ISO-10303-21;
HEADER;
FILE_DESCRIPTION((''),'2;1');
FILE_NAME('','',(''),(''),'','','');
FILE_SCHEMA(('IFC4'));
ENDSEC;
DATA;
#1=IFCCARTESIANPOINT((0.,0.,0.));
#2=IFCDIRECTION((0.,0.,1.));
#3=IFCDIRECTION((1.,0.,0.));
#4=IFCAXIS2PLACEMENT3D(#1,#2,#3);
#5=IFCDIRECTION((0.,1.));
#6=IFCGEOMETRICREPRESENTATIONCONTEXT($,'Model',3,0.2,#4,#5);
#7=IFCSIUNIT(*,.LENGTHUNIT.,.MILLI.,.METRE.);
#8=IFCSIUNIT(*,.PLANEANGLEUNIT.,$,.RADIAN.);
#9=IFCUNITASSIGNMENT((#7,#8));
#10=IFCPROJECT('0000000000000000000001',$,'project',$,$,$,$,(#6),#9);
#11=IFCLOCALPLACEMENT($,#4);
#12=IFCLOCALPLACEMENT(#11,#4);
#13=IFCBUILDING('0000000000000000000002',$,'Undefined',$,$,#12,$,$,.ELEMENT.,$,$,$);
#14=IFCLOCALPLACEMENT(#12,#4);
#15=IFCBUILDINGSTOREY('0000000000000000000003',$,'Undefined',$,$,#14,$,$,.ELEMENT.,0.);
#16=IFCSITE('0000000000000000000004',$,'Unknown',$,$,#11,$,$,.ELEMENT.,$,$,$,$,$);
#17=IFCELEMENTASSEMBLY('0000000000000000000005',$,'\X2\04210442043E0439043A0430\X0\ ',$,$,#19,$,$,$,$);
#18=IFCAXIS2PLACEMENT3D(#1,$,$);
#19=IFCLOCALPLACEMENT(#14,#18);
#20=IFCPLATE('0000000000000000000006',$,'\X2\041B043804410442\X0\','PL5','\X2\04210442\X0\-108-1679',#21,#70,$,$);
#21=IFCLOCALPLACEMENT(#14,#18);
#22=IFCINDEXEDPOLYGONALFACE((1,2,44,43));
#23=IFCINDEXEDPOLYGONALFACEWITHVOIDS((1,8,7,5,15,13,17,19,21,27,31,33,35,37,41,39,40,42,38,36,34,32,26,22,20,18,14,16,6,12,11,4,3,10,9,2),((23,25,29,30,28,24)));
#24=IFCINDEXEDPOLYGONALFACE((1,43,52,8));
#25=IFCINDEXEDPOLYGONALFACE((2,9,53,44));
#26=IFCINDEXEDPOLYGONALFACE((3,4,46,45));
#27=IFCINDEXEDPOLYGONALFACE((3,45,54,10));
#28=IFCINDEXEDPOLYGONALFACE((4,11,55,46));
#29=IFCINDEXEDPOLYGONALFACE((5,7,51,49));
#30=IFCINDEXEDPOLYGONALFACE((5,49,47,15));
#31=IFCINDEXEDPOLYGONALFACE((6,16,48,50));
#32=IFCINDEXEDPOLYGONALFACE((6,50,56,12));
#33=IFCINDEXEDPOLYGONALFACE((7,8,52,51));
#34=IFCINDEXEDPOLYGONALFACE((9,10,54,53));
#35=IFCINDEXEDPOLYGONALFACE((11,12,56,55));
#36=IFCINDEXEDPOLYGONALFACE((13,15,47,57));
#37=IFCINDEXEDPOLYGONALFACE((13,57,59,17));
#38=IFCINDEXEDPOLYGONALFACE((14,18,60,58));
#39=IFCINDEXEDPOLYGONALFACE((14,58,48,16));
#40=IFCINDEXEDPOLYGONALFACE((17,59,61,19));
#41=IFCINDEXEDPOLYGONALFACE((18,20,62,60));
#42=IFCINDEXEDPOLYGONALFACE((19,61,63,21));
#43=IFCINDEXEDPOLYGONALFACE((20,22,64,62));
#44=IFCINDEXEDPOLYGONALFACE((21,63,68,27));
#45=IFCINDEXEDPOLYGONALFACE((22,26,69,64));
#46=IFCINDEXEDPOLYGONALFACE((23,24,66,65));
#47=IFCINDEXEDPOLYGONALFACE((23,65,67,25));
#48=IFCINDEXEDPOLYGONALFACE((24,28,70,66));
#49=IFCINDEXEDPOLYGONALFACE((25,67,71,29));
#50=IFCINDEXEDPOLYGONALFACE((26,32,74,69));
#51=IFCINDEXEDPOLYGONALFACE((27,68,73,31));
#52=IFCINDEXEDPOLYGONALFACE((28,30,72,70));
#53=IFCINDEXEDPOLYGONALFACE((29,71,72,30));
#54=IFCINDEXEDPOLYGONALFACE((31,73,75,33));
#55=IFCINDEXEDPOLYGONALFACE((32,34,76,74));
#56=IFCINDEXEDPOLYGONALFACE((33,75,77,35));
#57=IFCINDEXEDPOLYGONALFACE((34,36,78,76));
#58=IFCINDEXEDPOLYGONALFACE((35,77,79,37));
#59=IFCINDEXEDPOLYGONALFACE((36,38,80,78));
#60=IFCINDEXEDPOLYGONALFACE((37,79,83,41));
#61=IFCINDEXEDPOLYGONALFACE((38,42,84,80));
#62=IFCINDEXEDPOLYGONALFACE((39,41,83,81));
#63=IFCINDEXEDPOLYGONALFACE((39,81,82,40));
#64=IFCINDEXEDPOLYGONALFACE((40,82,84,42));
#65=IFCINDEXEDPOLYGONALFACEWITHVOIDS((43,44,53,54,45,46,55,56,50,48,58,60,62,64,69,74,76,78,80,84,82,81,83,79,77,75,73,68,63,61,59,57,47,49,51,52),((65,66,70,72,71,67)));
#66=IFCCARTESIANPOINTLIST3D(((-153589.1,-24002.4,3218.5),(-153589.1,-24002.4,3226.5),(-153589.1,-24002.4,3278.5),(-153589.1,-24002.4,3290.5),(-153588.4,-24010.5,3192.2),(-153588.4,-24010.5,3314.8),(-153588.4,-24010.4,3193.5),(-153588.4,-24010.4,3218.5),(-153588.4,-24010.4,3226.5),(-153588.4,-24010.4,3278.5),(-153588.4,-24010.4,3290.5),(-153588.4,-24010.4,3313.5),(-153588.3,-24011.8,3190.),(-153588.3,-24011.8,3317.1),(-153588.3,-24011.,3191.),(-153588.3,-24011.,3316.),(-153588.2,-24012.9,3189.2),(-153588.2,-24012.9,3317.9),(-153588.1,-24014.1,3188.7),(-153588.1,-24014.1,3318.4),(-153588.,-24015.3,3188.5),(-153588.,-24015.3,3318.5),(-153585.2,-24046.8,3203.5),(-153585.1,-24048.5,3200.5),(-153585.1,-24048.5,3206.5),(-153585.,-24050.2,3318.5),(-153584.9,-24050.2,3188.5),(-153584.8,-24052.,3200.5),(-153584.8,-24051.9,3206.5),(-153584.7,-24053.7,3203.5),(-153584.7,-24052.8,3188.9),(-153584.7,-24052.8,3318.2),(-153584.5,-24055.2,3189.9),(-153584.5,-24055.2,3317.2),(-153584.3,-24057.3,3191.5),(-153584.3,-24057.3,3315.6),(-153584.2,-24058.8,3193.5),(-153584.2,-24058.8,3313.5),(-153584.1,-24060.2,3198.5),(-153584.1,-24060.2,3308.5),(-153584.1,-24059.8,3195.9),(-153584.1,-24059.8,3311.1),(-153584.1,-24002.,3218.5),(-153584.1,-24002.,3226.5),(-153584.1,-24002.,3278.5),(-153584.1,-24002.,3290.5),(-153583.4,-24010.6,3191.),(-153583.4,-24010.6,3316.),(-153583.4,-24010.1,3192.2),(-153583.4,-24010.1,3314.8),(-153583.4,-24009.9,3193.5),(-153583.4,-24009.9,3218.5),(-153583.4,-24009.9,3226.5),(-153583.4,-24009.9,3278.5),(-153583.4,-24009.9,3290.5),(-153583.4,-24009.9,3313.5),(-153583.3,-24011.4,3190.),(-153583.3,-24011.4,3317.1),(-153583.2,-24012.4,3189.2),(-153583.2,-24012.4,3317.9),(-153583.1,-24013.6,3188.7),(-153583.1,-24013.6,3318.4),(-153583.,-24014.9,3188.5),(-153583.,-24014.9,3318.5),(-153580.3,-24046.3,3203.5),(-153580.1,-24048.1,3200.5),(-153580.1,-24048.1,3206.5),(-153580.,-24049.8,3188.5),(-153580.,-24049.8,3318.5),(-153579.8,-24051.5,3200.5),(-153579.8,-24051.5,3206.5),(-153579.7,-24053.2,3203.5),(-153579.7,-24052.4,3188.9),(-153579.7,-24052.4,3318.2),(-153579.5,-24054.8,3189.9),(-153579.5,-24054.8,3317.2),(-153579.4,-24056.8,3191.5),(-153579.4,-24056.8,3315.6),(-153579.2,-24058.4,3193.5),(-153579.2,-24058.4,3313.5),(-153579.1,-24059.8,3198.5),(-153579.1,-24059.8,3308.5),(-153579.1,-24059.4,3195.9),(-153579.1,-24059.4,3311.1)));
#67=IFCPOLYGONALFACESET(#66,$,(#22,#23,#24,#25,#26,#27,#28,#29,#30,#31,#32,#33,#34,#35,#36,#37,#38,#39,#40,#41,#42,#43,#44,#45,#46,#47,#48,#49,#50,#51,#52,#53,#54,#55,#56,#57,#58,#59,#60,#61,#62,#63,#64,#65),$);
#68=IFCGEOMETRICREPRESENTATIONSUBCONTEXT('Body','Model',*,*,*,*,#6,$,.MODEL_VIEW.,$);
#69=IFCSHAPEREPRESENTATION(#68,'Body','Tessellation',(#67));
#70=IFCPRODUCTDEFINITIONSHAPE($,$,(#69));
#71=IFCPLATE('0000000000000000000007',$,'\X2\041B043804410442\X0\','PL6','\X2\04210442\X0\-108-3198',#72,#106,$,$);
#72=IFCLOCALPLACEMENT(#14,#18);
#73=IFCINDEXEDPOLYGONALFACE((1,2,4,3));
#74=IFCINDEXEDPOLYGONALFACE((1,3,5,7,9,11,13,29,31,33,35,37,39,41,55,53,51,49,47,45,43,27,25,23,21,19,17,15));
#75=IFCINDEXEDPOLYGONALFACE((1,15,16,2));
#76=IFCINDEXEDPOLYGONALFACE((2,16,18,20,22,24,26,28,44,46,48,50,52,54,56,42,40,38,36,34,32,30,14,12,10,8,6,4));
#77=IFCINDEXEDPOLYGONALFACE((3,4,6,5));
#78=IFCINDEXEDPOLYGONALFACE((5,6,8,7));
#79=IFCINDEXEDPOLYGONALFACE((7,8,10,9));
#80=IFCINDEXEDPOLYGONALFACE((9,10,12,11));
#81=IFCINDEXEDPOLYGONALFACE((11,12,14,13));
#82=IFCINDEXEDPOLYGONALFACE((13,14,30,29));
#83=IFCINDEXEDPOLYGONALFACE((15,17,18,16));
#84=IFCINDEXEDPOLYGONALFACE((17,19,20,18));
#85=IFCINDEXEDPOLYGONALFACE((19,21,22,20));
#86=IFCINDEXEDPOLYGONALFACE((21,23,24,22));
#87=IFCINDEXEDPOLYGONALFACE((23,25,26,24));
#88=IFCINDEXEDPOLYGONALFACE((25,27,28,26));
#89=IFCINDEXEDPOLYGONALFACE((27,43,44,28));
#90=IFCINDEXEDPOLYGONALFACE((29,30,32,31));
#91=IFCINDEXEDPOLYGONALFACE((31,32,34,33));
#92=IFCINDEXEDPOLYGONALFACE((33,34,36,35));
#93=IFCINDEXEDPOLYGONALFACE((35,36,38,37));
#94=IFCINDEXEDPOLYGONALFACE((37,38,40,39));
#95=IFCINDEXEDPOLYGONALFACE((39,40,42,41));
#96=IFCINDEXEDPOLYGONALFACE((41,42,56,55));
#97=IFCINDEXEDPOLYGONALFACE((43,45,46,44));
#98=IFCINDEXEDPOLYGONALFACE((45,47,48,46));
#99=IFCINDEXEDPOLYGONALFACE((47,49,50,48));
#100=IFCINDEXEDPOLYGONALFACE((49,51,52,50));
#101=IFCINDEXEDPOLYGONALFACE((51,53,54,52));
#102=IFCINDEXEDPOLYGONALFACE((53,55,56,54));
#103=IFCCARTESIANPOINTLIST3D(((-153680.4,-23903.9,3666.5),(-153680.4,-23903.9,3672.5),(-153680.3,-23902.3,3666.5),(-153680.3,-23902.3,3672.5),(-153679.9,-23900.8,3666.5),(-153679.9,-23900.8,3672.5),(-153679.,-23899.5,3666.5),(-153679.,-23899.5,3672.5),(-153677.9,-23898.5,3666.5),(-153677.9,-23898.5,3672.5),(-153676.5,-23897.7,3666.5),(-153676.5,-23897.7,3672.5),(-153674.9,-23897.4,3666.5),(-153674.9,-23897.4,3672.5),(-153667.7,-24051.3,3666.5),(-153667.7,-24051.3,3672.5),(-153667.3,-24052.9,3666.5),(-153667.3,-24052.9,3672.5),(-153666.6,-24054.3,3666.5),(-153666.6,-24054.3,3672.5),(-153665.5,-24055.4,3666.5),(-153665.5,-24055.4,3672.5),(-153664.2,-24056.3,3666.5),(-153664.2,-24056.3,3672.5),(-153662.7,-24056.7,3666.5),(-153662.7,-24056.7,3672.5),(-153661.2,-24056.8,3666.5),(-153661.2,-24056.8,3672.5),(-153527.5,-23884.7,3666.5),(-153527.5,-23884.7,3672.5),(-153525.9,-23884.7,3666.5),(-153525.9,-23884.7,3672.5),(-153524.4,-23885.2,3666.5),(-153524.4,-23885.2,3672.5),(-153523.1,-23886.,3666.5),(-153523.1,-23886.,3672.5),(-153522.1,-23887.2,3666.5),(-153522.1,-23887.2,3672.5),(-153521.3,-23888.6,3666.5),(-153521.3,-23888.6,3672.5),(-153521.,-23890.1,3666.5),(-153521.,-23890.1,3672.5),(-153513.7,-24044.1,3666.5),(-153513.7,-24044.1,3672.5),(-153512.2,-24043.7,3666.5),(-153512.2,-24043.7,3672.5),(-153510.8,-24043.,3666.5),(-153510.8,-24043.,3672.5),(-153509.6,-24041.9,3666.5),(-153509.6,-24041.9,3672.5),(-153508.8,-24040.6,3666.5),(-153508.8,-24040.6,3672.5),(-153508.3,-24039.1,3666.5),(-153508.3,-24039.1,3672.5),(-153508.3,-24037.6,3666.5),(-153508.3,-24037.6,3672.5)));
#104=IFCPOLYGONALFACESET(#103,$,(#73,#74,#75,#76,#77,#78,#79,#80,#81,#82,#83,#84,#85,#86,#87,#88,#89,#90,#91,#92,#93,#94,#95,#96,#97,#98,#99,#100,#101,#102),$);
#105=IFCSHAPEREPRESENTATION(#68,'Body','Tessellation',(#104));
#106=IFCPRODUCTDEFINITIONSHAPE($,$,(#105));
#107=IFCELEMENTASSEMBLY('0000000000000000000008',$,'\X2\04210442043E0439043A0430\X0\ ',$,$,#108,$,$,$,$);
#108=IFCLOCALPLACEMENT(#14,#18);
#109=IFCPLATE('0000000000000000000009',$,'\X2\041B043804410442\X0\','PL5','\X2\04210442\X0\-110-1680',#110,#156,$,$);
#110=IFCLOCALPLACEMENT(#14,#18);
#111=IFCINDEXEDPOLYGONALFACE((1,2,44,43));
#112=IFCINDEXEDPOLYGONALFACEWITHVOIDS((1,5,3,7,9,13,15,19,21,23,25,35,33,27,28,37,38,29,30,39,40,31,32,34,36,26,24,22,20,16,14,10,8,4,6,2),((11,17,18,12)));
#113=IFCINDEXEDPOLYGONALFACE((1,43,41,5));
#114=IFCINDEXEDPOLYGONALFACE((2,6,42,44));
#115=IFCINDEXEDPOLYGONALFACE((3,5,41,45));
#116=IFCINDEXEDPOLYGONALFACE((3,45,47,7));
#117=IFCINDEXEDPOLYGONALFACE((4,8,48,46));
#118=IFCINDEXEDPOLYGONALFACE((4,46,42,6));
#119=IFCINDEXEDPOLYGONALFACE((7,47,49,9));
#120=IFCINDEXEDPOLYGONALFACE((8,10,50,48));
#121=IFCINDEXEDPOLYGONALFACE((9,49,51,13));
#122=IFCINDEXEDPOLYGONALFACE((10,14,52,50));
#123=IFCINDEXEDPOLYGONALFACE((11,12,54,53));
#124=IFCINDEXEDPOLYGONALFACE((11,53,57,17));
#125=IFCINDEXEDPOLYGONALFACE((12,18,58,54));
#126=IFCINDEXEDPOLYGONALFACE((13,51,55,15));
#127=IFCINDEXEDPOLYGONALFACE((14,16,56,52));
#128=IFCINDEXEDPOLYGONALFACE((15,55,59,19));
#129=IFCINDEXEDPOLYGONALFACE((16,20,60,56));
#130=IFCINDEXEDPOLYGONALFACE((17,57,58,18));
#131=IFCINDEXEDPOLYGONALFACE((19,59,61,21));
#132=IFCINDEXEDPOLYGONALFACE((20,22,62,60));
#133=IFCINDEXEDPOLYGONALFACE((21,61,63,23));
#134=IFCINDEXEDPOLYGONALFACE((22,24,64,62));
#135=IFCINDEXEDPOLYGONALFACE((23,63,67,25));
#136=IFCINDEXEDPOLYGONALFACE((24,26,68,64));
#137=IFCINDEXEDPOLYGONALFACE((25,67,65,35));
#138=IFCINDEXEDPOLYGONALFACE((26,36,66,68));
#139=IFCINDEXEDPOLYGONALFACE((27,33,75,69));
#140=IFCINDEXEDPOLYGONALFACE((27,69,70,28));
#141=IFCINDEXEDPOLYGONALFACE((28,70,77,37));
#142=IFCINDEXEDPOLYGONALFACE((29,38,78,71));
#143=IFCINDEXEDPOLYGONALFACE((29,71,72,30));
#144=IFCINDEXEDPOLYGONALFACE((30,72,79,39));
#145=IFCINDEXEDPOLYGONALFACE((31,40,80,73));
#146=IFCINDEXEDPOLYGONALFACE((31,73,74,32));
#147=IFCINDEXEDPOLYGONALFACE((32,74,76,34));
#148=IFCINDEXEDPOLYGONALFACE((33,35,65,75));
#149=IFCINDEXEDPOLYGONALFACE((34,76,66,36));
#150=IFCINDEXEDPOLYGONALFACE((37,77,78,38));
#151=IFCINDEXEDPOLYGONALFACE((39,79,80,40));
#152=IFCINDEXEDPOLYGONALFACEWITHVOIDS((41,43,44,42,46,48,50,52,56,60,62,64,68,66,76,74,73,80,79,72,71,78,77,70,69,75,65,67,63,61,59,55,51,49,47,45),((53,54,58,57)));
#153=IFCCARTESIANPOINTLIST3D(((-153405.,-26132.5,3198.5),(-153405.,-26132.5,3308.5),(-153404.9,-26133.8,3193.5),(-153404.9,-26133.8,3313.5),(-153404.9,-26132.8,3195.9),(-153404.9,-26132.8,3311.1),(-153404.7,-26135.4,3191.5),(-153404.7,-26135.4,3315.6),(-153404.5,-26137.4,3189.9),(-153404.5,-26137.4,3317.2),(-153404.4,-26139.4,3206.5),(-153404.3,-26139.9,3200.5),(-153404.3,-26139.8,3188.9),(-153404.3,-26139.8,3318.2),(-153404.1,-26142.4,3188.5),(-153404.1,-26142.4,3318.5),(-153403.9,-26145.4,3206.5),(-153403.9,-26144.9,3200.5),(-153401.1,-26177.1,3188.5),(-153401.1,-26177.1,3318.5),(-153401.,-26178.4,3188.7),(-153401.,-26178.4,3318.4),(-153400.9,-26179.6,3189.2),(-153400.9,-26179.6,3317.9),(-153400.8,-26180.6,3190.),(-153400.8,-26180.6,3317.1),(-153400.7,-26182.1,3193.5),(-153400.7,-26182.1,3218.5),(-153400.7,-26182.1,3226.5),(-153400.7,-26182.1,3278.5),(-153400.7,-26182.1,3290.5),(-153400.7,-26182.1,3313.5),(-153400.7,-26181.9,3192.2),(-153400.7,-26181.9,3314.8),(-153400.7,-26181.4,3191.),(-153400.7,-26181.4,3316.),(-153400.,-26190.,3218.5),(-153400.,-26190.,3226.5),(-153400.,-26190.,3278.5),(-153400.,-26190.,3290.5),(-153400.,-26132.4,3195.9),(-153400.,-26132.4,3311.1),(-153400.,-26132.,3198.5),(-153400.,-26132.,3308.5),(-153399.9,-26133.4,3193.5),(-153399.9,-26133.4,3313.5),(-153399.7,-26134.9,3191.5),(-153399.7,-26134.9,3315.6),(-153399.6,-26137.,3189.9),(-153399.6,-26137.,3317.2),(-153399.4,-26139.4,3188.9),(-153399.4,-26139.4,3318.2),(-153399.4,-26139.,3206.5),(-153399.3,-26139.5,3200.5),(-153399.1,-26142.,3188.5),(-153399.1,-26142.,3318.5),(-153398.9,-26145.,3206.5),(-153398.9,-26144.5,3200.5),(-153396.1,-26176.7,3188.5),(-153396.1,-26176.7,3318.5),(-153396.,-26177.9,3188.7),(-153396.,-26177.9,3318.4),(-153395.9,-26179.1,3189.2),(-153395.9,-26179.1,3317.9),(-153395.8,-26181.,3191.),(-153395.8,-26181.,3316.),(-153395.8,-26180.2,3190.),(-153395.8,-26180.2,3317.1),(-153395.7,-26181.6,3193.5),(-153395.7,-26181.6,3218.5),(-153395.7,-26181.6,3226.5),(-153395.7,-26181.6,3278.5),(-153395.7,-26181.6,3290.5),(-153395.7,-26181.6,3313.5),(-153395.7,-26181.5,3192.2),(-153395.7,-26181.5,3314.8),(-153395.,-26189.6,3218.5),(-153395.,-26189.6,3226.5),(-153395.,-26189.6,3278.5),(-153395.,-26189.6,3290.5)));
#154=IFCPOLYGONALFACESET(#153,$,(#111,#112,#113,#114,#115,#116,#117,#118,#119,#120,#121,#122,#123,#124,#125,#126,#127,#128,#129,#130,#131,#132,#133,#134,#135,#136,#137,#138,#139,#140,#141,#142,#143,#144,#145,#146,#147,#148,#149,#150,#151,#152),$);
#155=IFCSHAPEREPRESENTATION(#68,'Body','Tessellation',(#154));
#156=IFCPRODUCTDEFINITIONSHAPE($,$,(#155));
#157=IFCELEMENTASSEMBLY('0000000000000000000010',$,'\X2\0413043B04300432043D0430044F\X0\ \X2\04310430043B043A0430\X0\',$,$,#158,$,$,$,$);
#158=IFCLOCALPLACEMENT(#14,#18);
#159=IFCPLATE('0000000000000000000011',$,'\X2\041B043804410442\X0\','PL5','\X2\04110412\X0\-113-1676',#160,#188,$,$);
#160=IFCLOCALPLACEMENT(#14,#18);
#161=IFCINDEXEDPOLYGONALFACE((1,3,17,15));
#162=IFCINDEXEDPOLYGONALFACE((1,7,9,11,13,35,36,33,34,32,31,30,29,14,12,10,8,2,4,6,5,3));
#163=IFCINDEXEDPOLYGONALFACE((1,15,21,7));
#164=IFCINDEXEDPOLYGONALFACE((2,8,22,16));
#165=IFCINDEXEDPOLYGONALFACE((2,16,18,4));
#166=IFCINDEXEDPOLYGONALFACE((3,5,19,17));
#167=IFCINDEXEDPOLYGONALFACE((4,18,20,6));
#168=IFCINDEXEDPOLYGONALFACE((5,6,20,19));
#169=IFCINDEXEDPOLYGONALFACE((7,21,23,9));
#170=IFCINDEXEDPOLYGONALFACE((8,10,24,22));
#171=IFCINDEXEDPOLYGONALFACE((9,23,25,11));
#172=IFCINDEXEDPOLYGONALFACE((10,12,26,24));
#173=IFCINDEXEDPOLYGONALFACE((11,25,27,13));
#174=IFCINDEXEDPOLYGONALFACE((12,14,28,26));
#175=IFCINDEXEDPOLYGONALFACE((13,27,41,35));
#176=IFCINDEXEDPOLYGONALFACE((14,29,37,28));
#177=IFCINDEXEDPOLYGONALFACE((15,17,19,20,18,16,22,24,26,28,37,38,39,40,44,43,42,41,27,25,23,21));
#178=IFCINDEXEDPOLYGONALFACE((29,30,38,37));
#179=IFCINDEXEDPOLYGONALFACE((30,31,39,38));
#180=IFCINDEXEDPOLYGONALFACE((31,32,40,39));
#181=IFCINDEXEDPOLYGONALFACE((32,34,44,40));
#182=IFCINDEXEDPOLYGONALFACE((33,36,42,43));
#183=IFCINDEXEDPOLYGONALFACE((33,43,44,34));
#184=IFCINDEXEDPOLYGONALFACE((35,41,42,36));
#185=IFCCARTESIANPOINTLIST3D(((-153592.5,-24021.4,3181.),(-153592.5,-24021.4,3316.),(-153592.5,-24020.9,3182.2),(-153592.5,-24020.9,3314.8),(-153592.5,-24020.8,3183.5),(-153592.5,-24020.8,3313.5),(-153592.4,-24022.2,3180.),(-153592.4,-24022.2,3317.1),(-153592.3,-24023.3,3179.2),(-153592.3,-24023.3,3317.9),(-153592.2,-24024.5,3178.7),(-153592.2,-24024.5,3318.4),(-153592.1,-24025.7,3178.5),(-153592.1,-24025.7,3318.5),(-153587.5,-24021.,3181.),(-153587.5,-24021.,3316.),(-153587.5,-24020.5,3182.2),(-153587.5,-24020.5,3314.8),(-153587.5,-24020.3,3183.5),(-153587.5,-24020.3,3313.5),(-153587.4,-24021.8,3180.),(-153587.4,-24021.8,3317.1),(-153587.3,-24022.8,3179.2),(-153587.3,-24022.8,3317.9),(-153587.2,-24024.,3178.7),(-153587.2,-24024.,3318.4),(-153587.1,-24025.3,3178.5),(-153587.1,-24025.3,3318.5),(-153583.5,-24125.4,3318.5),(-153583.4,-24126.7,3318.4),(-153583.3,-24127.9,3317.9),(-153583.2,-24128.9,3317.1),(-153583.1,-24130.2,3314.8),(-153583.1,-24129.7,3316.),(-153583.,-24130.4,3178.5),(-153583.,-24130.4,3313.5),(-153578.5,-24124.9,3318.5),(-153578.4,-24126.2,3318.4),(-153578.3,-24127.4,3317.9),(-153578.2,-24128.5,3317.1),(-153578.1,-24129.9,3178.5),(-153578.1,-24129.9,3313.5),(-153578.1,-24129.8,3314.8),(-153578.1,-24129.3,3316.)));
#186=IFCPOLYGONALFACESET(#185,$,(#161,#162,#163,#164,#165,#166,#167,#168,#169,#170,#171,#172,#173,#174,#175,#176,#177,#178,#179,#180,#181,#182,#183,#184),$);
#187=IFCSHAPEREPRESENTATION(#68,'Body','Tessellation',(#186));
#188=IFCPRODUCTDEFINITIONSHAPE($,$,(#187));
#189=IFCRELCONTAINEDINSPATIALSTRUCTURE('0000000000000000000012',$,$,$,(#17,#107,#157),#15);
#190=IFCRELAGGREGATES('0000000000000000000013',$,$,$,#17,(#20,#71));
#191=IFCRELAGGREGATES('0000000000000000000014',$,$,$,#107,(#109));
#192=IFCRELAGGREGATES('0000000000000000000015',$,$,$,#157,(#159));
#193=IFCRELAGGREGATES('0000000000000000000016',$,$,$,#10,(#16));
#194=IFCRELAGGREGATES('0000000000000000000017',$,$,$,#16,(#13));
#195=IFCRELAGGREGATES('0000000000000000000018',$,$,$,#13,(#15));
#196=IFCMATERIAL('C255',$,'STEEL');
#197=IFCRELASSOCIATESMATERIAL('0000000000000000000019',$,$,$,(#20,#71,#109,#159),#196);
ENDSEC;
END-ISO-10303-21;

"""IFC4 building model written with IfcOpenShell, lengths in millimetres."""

from ifc_helpers import new_model, si_unit, direction, frame, origin_with_axes, place, context, subcontext, project, spatial, line, arc, indexed_curve, outline, extrude, material, element, aggregate, save


model = new_model("IFC4")

# Units and contexts
model_context = context("Model", 3, precision=0.2, world=origin_with_axes(), true_north=direction((0.0, 1.0)))
body_context = subcontext(model_context, "Body", "Model", "MODEL_VIEW")
ifc_project = project(units=[si_unit("LENGTHUNIT", "METRE", prefix="MILLI"), si_unit("PLANEANGLEUNIT", "RADIAN")], contexts=[model_context])

# Site, building, storey
site_placement = place(None, origin_with_axes())
site = spatial("IfcSite", under=ifc_project, at=site_placement, Name="Unknown", CompositionType="ELEMENT")
building_placement = place(site_placement, origin_with_axes())
building = spatial("IfcBuilding", under=site, at=building_placement, Name="Undefined", CompositionType="ELEMENT")
storey_placement = place(building_placement, origin_with_axes())
storey = spatial("IfcBuildingStorey", under=building, at=storey_placement, Name="Undefined", CompositionType="ELEMENT", Elevation=0.0)

# Element assembly, plates, voiding feature
assembly_1_placement = place(storey_placement, frame((-153594.3, -23970.7, 698.5), z_axis=(-0.086114, 0.996285, 0.0), x_axis=(0.0, 0.0, 1.0)))
assembly_1 = element("IfcElementAssembly", 1, at=assembly_1_placement, inside=storey, Name="Стойка ")
ifc_material_1 = material(Name="C255", Category="STEEL")
plate_1_placement = place(assembly_1_placement, frame((2490.0, 5.0, -90.0), z_axis=(-0.000024, -1.0, 0.0), x_axis=(1.0, -0.000024, 0.0)))
plate_1 = element("IfcPlate", 2, at=plate_1_placement, material=ifc_material_1, Name="Лист", Description="PL5", ObjectType="Ст-108-1679", context=body_context, shape_type="SolidModel", body=[
    extrude(outline(indexed_curve([(0.0, 10.0), (2.9, 2.9), (10.0, 0.0), (120.0, 0.0), (127.1, 2.9), (130.0, 10.0), (130.0, 45.0), (128.5, 48.5), (125.0, 50.0), (102.0, 50.0), (102.0, 58.0), (90.0, 58.0), (90.0, 50.0), (38.0, 50.0), (38.0, 58.0), (30.0, 58.0), (30.0, 50.0), (5.0, 50.0), (1.5, 48.5), (0.0, 45.0)], segments=[arc(1, 2, 3), line(3, 4), arc(4, 5, 6), line(6, 7), arc(7, 8, 9), line(9, 10, 11, 12, 13, 14, 15, 16, 17, 18), arc(18, 19, 20), line(20, 1)])), frame((0.0, 0.0, 2.5), z_axis=(0.0, 0.0, 1.0), x_axis=(1.0, 0.0, 0.0)), (0.0, 0.0, -1.0), 5.0),
])
voiding_feature_1_placement = place(plate_1_placement, frame((15.0, 10.0, 10.0), z_axis=(0.003022, -0.999995, 0.0), x_axis=(0.0, 0.0, -1.0)))
element("IfcVoidingFeature", 3, at=voiding_feature_1_placement, cuts=plate_1, Name="Балка", ObjectType="(?)", PredefinedType="HOLE", context=body_context, shape_type="SolidModel", body=[
    extrude(outline(indexed_curve([(1.7, -3.0), (3.5, 0.0), (1.7, 3.0), (-1.7, 3.0), (-3.5, 0.0), (-1.7, -3.0)], segments=[line(1, 2, 3, 4, 5, 6, 1)])), frame((0.0, 0.0, 0.0), z_axis=(-1.0, 0.0, 0.0), x_axis=(0.0, 0.0, 1.0)), (0.0, 0.0, -1.0), 20.0),
])
plate_2_placement = place(assembly_1_placement, frame((2971.0, 80.0, -80.0), z_axis=(1.0, 0.0, 0.0), x_axis=(0.0, 0.0, 1.0)))
plate_2 = element("IfcPlate", 4, at=plate_2_placement, material=ifc_material_1, Name="Лист", Description="PL6", ObjectType="Ст-108-3198", context=body_context, shape_type="SolidModel", body=[
    extrude(outline(indexed_curve([(0.0, 6.0), (1.8, 1.8), (6.0, 0.0), (154.0, 0.0), (158.2, 1.8), (160.0, 6.0), (160.0, 154.0), (158.2, 158.2), (154.0, 160.0), (6.0, 160.0), (1.8, 158.2), (0.0, 154.0)], segments=[arc(1, 2, 3), line(3, 4), arc(4, 5, 6), line(6, 7), arc(7, 8, 9), line(9, 10), arc(10, 11, 12), line(12, 1)])), frame((0.0, 0.0, 3.0), z_axis=(0.0, 0.0, 1.0), x_axis=(1.0, 0.0, 0.0)), (0.0, 0.0, -1.0), 6.0),
])

# Element assembly, plate, voiding feature
assembly_2_placement = place(storey_placement, frame((-153388.9, -26231.4, 131.5), z_axis=(-0.086114, 0.996285, 0.0), x_axis=(0.0, 0.0, 1.0)))
assembly_2 = element("IfcElementAssembly", 5, at=assembly_2_placement, inside=storey, Name="Стойка ")
plate_3_placement = place(assembly_2_placement, frame((3057.0, -5.0, 100.0), z_axis=(0.000024, 1.0, 0.0), x_axis=(1.0, -0.000024, 0.0)))
plate_3 = element("IfcPlate", 6, at=plate_3_placement, material=ifc_material_1, Name="Лист", Description="PL5", ObjectType="Ст-110-1680", context=body_context, shape_type="SolidModel", body=[
    extrude(outline(indexed_curve([(0.0, 10.0), (2.9, 2.9), (10.0, 0.0), (120.0, 0.0), (127.1, 2.9), (130.0, 10.0), (130.0, 44.8), (128.5, 48.3), (125.0, 49.8), (102.0, 49.8), (102.0, 57.8), (90.0, 57.8), (90.0, 49.8), (38.0, 49.8), (38.0, 57.8), (30.0, 57.8), (30.0, 49.8), (5.0, 49.8), (1.5, 48.3), (0.0, 44.8)], segments=[arc(1, 2, 3), line(3, 4), arc(4, 5, 6), line(6, 7), arc(7, 8, 9), line(9, 10, 11, 12, 13, 14, 15, 16, 17, 18), arc(18, 19, 20), line(20, 1)])), frame((0.0, 0.0, 2.5), z_axis=(0.0, 0.0, 1.0), x_axis=(1.0, 0.0, 0.0)), (0.0, 0.0, -1.0), 5.0),
])
voiding_feature_2_placement = place(plate_3_placement, frame((15.0, 10.0, 10.0), z_axis=(0.003022, -0.999995, 0.0), x_axis=(0.0, 0.0, -1.0)))
element("IfcVoidingFeature", 7, at=voiding_feature_2_placement, cuts=plate_3, Name="Балка", ObjectType="(?)", PredefinedType="HOLE", context=body_context, shape_type="SolidModel", body=[
    extrude(outline(indexed_curve([(2.5, -3.0), (3.0, 3.0), (-3.0, 3.0), (-2.5, -3.0)], segments=[line(1, 2, 3, 4, 1)])), frame((0.0, 0.0, 0.0), z_axis=(-1.0, 0.0, 0.0), x_axis=(0.0, 0.0, 1.0)), (0.0, 0.0, -1.0), 20.0),
])

# Element assembly, plate
assembly_3_placement = place(storey_placement, frame((-153409.2, -26112.7, 3248.5), z_axis=(-0.996285, -0.086114, -0.000024), x_axis=(-0.086114, 0.996285, 0.0)))
assembly_3 = element("IfcElementAssembly", 8, at=assembly_3_placement, inside=storey, Name="Главная балка")
plate_4_placement = place(assembly_3_placement, frame((2100.0, -70.0, 0.0), z_axis=(0.0, 0.0, 1.0), x_axis=(0.0, 1.0, 0.0)))
plate_4 = element("IfcPlate", 9, at=plate_4_placement, material=ifc_material_1, Name="Лист", Description="PL5", ObjectType="БВ-113-1676", context=body_context, shape_type="SolidModel", body=[
    extrude(outline(indexed_curve([(0.0, 5.0), (1.5, 1.5), (5.0, 0.0), (135.0, 0.0), (138.5, 1.5), (140.0, 5.0), (140.0, 110.0), (5.0, 110.0), (1.5, 108.5), (0.0, 105.0)], segments=[arc(1, 2, 3), line(3, 4), arc(4, 5, 6), line(6, 7, 8), arc(8, 9, 10), line(10, 1)])), frame((0.0, 0.0, 2.5), z_axis=(0.0, 0.0, 1.0), x_axis=(1.0, 0.0, 0.0)), (0.0, 0.0, -1.0), 5.0),
])

aggregate(assembly_1, [plate_1, plate_2])
aggregate(assembly_2, [plate_3])
aggregate(assembly_3, [plate_4])

save(model, "model.ifc")
